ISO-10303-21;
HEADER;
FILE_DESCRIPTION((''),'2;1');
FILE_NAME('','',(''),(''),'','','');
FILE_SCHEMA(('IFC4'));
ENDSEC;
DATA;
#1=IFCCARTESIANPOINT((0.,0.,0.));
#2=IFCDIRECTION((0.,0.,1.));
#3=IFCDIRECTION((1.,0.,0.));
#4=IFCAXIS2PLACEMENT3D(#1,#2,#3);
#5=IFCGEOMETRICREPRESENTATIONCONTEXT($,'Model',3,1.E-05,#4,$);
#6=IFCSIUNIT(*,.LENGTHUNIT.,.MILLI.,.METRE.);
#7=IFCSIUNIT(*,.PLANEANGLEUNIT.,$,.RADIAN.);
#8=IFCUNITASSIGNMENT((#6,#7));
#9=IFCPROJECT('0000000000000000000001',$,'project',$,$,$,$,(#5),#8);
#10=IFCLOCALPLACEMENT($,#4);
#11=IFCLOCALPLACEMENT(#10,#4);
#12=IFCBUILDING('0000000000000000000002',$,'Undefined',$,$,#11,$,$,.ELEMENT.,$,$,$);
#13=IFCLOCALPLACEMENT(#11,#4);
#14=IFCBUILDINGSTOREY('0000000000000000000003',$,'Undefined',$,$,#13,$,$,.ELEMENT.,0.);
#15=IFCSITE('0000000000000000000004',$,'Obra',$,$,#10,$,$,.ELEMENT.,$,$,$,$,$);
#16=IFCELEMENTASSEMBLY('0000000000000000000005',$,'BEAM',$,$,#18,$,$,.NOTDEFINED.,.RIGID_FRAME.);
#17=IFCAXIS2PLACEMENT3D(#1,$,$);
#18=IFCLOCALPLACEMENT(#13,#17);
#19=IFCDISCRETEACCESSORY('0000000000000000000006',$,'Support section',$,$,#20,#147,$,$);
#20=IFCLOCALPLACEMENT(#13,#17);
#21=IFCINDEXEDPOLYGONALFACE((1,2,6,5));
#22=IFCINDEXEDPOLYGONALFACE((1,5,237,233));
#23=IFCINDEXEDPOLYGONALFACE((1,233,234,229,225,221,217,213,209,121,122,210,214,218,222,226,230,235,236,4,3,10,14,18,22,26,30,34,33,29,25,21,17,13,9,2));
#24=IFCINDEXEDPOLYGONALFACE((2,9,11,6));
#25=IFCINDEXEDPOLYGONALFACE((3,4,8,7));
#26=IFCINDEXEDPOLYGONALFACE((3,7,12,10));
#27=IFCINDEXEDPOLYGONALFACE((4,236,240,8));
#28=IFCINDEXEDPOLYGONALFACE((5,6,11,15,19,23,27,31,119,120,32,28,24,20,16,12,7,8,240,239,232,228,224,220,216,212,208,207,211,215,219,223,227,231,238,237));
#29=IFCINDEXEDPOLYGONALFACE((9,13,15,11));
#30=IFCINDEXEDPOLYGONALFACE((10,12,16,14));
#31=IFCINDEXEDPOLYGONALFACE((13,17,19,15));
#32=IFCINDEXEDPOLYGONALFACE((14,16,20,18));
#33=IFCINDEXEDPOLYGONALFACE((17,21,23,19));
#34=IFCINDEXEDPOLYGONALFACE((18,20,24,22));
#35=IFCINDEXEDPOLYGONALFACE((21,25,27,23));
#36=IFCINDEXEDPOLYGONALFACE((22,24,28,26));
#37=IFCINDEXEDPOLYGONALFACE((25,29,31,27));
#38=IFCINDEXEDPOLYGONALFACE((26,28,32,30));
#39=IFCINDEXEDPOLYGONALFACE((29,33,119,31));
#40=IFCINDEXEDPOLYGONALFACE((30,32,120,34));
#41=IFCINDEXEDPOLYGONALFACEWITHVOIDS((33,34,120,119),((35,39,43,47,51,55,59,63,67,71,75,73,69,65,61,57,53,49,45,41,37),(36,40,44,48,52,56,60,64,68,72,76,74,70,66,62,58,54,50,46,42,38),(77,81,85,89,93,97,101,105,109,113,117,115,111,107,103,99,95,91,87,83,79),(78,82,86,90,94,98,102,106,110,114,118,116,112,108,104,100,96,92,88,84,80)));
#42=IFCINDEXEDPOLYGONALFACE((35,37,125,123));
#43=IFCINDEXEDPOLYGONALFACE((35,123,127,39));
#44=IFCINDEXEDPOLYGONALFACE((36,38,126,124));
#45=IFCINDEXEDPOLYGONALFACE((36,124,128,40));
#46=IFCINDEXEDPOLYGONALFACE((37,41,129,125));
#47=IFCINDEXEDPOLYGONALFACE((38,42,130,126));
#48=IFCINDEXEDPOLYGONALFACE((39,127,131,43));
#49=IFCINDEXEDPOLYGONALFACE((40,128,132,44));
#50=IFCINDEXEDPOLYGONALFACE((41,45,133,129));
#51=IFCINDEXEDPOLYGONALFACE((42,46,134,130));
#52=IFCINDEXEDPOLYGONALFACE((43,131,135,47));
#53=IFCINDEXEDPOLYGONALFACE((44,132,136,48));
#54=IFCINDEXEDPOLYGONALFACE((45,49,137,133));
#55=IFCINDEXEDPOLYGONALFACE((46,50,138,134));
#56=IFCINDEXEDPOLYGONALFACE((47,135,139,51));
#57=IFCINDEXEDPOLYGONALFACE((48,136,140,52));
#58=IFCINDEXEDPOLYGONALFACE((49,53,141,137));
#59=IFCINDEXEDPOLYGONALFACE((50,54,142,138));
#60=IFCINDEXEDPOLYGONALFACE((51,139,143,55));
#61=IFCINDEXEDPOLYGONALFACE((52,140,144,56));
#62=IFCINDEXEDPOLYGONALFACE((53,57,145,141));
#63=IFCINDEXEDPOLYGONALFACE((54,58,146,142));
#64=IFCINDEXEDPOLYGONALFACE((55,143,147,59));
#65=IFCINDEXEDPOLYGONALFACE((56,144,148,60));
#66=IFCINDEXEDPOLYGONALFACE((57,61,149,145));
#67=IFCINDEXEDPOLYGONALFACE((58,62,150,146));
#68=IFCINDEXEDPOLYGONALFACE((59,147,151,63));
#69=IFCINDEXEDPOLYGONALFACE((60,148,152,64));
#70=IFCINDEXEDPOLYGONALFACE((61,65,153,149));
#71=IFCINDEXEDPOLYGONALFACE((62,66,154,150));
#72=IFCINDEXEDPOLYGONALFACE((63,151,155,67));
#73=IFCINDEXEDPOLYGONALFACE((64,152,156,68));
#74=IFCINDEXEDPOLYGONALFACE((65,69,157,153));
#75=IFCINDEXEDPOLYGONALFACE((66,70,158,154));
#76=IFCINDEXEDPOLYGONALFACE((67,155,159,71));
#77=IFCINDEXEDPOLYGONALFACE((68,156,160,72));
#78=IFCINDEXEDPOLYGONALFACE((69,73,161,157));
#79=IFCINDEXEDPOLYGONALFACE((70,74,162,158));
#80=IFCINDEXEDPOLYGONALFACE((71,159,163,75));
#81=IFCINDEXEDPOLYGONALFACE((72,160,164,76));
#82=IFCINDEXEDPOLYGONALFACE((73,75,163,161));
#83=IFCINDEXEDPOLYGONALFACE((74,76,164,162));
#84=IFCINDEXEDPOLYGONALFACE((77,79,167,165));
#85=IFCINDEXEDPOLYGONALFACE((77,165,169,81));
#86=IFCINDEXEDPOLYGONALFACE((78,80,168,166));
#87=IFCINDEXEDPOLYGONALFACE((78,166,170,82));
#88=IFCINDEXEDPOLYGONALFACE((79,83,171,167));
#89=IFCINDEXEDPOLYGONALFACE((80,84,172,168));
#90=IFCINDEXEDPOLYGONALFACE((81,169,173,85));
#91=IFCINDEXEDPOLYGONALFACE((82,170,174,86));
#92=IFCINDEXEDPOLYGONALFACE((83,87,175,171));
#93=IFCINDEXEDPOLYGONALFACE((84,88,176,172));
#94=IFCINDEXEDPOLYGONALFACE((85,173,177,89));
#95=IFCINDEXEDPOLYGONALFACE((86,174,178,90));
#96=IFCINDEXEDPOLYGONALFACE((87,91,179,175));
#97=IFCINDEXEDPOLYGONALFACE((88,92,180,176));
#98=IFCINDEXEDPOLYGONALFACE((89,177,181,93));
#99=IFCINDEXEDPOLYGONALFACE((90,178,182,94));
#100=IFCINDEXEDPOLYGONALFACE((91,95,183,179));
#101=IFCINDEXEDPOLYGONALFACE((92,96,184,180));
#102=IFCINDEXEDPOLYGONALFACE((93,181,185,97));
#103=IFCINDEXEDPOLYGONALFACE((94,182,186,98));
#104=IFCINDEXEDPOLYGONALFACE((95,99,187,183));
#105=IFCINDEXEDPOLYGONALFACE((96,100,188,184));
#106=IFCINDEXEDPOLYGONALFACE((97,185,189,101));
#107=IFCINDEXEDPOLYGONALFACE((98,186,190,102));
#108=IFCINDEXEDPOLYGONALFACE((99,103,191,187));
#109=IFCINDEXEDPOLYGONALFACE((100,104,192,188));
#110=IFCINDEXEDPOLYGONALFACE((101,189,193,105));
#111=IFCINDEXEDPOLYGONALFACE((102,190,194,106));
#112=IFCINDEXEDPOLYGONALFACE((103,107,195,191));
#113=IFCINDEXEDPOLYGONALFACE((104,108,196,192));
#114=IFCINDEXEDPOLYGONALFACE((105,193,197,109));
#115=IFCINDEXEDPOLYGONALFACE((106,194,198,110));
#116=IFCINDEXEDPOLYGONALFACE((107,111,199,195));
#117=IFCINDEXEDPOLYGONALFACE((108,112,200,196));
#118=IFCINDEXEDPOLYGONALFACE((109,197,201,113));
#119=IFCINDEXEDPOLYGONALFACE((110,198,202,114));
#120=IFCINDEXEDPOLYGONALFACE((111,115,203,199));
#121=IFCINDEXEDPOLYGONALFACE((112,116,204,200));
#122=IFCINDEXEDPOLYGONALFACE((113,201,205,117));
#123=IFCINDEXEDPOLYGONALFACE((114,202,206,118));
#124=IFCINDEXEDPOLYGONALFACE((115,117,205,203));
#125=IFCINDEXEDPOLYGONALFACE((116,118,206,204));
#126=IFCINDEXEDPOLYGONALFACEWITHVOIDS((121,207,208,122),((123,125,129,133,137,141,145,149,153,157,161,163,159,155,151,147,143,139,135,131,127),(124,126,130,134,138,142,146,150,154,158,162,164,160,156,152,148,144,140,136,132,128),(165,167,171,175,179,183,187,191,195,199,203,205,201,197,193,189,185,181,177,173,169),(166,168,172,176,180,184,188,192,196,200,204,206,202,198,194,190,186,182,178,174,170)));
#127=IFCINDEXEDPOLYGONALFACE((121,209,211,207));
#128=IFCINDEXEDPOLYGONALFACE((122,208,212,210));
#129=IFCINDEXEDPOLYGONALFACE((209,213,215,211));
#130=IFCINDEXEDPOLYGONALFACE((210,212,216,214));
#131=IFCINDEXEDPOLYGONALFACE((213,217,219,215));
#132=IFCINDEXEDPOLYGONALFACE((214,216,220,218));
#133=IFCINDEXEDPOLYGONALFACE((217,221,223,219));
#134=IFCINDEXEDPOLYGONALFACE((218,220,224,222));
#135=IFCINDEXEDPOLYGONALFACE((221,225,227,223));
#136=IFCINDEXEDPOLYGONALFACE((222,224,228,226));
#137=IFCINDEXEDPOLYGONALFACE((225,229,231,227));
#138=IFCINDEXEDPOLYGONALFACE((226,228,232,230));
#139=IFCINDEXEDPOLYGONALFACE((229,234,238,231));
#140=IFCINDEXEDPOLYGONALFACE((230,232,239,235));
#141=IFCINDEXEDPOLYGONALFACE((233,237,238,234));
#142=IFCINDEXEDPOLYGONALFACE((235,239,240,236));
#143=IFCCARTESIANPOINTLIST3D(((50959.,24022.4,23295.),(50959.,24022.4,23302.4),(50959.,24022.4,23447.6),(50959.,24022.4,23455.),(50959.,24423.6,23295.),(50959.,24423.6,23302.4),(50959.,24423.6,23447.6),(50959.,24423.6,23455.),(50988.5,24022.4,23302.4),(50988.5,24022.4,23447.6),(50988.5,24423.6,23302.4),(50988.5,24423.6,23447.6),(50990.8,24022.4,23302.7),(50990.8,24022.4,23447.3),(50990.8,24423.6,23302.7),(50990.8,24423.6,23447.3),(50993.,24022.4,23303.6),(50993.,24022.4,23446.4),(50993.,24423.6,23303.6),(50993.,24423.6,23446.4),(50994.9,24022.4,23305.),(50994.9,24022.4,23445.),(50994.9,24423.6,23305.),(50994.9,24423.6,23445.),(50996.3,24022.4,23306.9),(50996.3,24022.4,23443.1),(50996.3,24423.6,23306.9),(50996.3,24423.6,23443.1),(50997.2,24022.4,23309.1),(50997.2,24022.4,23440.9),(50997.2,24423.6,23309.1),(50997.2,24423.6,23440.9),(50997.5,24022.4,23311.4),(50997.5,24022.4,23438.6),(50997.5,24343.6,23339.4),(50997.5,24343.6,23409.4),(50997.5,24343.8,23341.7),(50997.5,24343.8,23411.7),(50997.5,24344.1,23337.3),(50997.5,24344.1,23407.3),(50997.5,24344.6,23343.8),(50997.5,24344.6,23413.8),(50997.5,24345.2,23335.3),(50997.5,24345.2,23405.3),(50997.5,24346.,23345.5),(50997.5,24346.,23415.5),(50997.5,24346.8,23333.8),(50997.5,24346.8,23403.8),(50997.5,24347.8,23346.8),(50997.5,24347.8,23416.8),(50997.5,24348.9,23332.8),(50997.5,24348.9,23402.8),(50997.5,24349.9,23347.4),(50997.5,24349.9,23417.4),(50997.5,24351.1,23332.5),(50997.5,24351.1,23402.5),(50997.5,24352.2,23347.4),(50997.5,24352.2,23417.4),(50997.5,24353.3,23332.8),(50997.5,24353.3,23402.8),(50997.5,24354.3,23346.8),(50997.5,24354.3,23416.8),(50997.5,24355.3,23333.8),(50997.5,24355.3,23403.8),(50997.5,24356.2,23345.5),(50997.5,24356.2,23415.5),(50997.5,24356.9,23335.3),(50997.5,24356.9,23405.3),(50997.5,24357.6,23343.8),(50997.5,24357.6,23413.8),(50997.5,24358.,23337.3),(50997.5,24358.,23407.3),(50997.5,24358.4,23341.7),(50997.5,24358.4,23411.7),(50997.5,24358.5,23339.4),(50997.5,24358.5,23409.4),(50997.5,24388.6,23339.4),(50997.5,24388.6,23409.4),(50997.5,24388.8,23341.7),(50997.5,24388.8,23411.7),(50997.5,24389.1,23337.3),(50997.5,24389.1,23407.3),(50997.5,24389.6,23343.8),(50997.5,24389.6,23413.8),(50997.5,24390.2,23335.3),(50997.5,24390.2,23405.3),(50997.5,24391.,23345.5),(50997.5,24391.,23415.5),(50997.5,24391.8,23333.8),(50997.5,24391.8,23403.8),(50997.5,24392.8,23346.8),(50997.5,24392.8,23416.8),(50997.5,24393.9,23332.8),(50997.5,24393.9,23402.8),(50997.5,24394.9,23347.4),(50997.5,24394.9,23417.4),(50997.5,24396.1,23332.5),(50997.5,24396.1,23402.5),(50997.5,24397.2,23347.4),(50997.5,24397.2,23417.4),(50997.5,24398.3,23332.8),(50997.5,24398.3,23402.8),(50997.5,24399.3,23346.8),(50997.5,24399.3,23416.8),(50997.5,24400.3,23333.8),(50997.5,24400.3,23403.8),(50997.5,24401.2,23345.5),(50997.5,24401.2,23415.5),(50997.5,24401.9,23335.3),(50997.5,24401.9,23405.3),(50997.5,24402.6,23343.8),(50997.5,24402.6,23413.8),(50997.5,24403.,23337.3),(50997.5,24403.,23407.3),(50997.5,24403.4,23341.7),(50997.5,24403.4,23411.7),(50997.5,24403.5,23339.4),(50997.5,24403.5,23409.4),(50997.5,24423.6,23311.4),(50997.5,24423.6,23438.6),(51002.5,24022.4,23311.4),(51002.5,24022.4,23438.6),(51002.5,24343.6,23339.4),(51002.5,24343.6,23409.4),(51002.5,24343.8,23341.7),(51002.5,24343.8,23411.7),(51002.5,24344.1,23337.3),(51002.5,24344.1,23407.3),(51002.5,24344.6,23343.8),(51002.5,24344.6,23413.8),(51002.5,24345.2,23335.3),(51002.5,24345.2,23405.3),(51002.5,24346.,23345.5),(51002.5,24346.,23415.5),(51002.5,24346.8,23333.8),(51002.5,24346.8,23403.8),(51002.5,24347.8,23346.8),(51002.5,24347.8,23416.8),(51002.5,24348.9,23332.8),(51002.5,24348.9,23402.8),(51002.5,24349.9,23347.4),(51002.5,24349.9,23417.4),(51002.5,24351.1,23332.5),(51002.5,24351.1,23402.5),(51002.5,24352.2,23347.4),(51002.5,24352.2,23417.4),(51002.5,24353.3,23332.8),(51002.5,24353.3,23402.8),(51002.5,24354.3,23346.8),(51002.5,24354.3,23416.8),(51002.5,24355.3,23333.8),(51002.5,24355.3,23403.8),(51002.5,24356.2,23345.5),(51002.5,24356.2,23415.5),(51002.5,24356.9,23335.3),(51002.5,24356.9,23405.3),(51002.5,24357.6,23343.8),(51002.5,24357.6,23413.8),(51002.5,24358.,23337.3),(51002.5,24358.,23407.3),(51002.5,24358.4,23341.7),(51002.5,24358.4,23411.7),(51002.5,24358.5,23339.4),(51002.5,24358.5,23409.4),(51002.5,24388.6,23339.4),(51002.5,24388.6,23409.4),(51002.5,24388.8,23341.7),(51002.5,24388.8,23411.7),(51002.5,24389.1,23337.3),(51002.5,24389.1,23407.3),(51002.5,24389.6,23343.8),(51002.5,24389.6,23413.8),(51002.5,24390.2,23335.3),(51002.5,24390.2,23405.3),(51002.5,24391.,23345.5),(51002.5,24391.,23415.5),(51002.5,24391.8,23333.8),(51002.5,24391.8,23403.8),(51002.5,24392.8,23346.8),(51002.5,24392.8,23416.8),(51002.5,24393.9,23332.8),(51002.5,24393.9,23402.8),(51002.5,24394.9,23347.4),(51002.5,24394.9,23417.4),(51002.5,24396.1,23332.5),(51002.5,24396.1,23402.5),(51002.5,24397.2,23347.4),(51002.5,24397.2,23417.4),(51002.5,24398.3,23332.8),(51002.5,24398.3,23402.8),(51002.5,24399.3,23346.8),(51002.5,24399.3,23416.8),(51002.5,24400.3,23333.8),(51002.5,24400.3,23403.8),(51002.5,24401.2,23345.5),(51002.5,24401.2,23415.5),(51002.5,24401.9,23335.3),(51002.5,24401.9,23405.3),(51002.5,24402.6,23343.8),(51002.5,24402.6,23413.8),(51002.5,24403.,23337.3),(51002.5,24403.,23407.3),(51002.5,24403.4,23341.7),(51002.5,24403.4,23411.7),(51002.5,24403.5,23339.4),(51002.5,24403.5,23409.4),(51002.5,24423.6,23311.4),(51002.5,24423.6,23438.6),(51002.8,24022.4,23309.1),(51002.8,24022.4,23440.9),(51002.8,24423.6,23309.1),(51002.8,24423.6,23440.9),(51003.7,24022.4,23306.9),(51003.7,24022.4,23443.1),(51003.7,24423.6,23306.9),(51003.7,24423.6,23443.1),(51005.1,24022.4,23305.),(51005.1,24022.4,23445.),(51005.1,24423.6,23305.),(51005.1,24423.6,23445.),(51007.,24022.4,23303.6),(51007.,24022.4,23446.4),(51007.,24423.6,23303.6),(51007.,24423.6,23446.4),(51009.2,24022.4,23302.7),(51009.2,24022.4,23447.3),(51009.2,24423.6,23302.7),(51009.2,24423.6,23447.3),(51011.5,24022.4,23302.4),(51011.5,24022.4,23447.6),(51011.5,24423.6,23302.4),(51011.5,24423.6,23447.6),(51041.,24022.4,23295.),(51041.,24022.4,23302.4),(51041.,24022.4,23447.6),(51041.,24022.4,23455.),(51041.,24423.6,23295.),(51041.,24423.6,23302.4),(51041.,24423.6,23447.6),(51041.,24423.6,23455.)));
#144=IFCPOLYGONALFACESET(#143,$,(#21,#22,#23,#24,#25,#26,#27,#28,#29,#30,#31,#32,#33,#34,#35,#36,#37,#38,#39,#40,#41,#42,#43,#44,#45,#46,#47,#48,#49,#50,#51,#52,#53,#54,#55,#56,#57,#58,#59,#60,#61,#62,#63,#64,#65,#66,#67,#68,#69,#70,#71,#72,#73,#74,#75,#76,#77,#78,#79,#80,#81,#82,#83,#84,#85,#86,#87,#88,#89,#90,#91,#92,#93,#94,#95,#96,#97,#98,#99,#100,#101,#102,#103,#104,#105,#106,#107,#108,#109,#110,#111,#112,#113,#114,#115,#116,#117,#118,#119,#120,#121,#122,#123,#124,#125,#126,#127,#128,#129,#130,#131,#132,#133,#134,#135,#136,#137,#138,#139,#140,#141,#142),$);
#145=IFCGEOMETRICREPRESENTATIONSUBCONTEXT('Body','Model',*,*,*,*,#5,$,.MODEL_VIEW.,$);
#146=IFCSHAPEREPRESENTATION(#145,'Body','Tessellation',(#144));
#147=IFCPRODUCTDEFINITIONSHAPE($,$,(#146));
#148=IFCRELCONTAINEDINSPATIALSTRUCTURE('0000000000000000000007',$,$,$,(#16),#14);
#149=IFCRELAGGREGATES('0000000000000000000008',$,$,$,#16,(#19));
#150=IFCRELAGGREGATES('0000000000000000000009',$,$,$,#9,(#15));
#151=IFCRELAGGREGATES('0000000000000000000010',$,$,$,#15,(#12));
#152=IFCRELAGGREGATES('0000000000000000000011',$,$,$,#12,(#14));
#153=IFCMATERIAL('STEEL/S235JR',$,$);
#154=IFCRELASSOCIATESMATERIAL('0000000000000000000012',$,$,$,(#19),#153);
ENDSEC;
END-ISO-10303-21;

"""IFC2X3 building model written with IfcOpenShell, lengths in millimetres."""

from ifc_helpers import new_model, si_unit, frame, origin_with_axes, origin_2d_with_axis, place, context, subcontext, project, spatial, circle, i_section, extrude, clip, halfspace, source, transform, mapped, material, element, aggregate, save


model = new_model("IFC2X3")

# Units and contexts
model_context = context("Model", 3, precision=1e-05, world=origin_with_axes())
body_context = subcontext(model_context, "Body", "Model", "MODEL_VIEW")
ifc_project = project(units=[si_unit("LENGTHUNIT", "METRE", prefix="MILLI"), si_unit("PLANEANGLEUNIT", "RADIAN")], contexts=[model_context])

# Site, building, storey
site_placement = place(None, origin_with_axes())
site = spatial("IfcSite", under=ifc_project, at=site_placement, Name="Obra", CompositionType="ELEMENT")
building_placement = place(site_placement, origin_with_axes())
building = spatial("IfcBuilding", under=site, at=building_placement, Name="Undefined", CompositionType="ELEMENT")
storey_placement = place(building_placement, origin_with_axes())
storey = spatial("IfcBuildingStorey", under=building, at=storey_placement, Name="Undefined", CompositionType="ELEMENT", Elevation=0.0)

# Shared definitions
ifc_material_1 = material(Name="STEEL/S235JR")

# Element assembly
assembly_1_placement = place(storey_placement, origin_with_axes())
assembly_1 = element("IfcElementAssembly", 1, at=assembly_1_placement, inside=storey, Name="BEAM", AssemblyPlace="NOTDEFINED", PredefinedType="RIGID_FRAME")

# Discrete accessory, opening
discrete_accessory_1_placement = place(assembly_1_placement, frame((51000.0, 24022.4, 23375.0), z_axis=(0.0, 0.0, 1.0), x_axis=(0.0, 1.0, 0.0)))
discrete_accessory_1 = element("IfcDiscreteAccessory", 2, at=discrete_accessory_1_placement, material=ifc_material_1, Name="Support section", context=body_context, shape_type="Clipping", body=[
    clip(extrude(i_section(OverallWidth=82.0, OverallDepth=160.0, WebThickness=5.0, FlangeThickness=7.4, FilletRadius=9.0, at=origin_2d_with_axis()), frame((401.2, 0.0, 0.0), z_axis=(-1.0, 0.0, 0.0), x_axis=(0.0, -1.0, 0.0)), (0.0, 0.0, 1.0), 401.2), halfspace(frame((401.2, 0.0, -180.0), z_axis=(-1.0, 0.0, 0.0), x_axis=(0.0, 1.0, 0.0)), True)),
])
shared_shape_1 = source(origin_with_axes(), body_context, "Body", "SweptSolid", [
    extrude(circle(Radius=7.5, at=origin_2d_with_axis()), frame((0.0, -2.6, 0.0), z_axis=(0.0, 1.0, 0.0), x_axis=(1.0, 0.0, 0.0)), (0.0, 0.0, 1.0), 5.2),
])
opening_1_placement = place(assembly_1_placement, frame((51000.0, 24373.6, 23410.0), z_axis=(0.0, -1.0, 0.0), x_axis=(0.0, 0.0, -1.0)))
element("IfcOpeningElement", 3, at=opening_1_placement, cuts=discrete_accessory_1, ObjectType="Opening", context=body_context, shape_type="MappedRepresentation", body=[
    mapped(shared_shape_1, transform((0.0, 0.0, -22.5))),
    mapped(shared_shape_1, transform((70.0, 0.0, -22.5))),
    mapped(shared_shape_1, transform((0.0, 0.0, 22.5))),
    mapped(shared_shape_1, transform((70.0, 0.0, 22.5))),
])
aggregate(assembly_1, [discrete_accessory_1])

save(model, "model.ifc")
